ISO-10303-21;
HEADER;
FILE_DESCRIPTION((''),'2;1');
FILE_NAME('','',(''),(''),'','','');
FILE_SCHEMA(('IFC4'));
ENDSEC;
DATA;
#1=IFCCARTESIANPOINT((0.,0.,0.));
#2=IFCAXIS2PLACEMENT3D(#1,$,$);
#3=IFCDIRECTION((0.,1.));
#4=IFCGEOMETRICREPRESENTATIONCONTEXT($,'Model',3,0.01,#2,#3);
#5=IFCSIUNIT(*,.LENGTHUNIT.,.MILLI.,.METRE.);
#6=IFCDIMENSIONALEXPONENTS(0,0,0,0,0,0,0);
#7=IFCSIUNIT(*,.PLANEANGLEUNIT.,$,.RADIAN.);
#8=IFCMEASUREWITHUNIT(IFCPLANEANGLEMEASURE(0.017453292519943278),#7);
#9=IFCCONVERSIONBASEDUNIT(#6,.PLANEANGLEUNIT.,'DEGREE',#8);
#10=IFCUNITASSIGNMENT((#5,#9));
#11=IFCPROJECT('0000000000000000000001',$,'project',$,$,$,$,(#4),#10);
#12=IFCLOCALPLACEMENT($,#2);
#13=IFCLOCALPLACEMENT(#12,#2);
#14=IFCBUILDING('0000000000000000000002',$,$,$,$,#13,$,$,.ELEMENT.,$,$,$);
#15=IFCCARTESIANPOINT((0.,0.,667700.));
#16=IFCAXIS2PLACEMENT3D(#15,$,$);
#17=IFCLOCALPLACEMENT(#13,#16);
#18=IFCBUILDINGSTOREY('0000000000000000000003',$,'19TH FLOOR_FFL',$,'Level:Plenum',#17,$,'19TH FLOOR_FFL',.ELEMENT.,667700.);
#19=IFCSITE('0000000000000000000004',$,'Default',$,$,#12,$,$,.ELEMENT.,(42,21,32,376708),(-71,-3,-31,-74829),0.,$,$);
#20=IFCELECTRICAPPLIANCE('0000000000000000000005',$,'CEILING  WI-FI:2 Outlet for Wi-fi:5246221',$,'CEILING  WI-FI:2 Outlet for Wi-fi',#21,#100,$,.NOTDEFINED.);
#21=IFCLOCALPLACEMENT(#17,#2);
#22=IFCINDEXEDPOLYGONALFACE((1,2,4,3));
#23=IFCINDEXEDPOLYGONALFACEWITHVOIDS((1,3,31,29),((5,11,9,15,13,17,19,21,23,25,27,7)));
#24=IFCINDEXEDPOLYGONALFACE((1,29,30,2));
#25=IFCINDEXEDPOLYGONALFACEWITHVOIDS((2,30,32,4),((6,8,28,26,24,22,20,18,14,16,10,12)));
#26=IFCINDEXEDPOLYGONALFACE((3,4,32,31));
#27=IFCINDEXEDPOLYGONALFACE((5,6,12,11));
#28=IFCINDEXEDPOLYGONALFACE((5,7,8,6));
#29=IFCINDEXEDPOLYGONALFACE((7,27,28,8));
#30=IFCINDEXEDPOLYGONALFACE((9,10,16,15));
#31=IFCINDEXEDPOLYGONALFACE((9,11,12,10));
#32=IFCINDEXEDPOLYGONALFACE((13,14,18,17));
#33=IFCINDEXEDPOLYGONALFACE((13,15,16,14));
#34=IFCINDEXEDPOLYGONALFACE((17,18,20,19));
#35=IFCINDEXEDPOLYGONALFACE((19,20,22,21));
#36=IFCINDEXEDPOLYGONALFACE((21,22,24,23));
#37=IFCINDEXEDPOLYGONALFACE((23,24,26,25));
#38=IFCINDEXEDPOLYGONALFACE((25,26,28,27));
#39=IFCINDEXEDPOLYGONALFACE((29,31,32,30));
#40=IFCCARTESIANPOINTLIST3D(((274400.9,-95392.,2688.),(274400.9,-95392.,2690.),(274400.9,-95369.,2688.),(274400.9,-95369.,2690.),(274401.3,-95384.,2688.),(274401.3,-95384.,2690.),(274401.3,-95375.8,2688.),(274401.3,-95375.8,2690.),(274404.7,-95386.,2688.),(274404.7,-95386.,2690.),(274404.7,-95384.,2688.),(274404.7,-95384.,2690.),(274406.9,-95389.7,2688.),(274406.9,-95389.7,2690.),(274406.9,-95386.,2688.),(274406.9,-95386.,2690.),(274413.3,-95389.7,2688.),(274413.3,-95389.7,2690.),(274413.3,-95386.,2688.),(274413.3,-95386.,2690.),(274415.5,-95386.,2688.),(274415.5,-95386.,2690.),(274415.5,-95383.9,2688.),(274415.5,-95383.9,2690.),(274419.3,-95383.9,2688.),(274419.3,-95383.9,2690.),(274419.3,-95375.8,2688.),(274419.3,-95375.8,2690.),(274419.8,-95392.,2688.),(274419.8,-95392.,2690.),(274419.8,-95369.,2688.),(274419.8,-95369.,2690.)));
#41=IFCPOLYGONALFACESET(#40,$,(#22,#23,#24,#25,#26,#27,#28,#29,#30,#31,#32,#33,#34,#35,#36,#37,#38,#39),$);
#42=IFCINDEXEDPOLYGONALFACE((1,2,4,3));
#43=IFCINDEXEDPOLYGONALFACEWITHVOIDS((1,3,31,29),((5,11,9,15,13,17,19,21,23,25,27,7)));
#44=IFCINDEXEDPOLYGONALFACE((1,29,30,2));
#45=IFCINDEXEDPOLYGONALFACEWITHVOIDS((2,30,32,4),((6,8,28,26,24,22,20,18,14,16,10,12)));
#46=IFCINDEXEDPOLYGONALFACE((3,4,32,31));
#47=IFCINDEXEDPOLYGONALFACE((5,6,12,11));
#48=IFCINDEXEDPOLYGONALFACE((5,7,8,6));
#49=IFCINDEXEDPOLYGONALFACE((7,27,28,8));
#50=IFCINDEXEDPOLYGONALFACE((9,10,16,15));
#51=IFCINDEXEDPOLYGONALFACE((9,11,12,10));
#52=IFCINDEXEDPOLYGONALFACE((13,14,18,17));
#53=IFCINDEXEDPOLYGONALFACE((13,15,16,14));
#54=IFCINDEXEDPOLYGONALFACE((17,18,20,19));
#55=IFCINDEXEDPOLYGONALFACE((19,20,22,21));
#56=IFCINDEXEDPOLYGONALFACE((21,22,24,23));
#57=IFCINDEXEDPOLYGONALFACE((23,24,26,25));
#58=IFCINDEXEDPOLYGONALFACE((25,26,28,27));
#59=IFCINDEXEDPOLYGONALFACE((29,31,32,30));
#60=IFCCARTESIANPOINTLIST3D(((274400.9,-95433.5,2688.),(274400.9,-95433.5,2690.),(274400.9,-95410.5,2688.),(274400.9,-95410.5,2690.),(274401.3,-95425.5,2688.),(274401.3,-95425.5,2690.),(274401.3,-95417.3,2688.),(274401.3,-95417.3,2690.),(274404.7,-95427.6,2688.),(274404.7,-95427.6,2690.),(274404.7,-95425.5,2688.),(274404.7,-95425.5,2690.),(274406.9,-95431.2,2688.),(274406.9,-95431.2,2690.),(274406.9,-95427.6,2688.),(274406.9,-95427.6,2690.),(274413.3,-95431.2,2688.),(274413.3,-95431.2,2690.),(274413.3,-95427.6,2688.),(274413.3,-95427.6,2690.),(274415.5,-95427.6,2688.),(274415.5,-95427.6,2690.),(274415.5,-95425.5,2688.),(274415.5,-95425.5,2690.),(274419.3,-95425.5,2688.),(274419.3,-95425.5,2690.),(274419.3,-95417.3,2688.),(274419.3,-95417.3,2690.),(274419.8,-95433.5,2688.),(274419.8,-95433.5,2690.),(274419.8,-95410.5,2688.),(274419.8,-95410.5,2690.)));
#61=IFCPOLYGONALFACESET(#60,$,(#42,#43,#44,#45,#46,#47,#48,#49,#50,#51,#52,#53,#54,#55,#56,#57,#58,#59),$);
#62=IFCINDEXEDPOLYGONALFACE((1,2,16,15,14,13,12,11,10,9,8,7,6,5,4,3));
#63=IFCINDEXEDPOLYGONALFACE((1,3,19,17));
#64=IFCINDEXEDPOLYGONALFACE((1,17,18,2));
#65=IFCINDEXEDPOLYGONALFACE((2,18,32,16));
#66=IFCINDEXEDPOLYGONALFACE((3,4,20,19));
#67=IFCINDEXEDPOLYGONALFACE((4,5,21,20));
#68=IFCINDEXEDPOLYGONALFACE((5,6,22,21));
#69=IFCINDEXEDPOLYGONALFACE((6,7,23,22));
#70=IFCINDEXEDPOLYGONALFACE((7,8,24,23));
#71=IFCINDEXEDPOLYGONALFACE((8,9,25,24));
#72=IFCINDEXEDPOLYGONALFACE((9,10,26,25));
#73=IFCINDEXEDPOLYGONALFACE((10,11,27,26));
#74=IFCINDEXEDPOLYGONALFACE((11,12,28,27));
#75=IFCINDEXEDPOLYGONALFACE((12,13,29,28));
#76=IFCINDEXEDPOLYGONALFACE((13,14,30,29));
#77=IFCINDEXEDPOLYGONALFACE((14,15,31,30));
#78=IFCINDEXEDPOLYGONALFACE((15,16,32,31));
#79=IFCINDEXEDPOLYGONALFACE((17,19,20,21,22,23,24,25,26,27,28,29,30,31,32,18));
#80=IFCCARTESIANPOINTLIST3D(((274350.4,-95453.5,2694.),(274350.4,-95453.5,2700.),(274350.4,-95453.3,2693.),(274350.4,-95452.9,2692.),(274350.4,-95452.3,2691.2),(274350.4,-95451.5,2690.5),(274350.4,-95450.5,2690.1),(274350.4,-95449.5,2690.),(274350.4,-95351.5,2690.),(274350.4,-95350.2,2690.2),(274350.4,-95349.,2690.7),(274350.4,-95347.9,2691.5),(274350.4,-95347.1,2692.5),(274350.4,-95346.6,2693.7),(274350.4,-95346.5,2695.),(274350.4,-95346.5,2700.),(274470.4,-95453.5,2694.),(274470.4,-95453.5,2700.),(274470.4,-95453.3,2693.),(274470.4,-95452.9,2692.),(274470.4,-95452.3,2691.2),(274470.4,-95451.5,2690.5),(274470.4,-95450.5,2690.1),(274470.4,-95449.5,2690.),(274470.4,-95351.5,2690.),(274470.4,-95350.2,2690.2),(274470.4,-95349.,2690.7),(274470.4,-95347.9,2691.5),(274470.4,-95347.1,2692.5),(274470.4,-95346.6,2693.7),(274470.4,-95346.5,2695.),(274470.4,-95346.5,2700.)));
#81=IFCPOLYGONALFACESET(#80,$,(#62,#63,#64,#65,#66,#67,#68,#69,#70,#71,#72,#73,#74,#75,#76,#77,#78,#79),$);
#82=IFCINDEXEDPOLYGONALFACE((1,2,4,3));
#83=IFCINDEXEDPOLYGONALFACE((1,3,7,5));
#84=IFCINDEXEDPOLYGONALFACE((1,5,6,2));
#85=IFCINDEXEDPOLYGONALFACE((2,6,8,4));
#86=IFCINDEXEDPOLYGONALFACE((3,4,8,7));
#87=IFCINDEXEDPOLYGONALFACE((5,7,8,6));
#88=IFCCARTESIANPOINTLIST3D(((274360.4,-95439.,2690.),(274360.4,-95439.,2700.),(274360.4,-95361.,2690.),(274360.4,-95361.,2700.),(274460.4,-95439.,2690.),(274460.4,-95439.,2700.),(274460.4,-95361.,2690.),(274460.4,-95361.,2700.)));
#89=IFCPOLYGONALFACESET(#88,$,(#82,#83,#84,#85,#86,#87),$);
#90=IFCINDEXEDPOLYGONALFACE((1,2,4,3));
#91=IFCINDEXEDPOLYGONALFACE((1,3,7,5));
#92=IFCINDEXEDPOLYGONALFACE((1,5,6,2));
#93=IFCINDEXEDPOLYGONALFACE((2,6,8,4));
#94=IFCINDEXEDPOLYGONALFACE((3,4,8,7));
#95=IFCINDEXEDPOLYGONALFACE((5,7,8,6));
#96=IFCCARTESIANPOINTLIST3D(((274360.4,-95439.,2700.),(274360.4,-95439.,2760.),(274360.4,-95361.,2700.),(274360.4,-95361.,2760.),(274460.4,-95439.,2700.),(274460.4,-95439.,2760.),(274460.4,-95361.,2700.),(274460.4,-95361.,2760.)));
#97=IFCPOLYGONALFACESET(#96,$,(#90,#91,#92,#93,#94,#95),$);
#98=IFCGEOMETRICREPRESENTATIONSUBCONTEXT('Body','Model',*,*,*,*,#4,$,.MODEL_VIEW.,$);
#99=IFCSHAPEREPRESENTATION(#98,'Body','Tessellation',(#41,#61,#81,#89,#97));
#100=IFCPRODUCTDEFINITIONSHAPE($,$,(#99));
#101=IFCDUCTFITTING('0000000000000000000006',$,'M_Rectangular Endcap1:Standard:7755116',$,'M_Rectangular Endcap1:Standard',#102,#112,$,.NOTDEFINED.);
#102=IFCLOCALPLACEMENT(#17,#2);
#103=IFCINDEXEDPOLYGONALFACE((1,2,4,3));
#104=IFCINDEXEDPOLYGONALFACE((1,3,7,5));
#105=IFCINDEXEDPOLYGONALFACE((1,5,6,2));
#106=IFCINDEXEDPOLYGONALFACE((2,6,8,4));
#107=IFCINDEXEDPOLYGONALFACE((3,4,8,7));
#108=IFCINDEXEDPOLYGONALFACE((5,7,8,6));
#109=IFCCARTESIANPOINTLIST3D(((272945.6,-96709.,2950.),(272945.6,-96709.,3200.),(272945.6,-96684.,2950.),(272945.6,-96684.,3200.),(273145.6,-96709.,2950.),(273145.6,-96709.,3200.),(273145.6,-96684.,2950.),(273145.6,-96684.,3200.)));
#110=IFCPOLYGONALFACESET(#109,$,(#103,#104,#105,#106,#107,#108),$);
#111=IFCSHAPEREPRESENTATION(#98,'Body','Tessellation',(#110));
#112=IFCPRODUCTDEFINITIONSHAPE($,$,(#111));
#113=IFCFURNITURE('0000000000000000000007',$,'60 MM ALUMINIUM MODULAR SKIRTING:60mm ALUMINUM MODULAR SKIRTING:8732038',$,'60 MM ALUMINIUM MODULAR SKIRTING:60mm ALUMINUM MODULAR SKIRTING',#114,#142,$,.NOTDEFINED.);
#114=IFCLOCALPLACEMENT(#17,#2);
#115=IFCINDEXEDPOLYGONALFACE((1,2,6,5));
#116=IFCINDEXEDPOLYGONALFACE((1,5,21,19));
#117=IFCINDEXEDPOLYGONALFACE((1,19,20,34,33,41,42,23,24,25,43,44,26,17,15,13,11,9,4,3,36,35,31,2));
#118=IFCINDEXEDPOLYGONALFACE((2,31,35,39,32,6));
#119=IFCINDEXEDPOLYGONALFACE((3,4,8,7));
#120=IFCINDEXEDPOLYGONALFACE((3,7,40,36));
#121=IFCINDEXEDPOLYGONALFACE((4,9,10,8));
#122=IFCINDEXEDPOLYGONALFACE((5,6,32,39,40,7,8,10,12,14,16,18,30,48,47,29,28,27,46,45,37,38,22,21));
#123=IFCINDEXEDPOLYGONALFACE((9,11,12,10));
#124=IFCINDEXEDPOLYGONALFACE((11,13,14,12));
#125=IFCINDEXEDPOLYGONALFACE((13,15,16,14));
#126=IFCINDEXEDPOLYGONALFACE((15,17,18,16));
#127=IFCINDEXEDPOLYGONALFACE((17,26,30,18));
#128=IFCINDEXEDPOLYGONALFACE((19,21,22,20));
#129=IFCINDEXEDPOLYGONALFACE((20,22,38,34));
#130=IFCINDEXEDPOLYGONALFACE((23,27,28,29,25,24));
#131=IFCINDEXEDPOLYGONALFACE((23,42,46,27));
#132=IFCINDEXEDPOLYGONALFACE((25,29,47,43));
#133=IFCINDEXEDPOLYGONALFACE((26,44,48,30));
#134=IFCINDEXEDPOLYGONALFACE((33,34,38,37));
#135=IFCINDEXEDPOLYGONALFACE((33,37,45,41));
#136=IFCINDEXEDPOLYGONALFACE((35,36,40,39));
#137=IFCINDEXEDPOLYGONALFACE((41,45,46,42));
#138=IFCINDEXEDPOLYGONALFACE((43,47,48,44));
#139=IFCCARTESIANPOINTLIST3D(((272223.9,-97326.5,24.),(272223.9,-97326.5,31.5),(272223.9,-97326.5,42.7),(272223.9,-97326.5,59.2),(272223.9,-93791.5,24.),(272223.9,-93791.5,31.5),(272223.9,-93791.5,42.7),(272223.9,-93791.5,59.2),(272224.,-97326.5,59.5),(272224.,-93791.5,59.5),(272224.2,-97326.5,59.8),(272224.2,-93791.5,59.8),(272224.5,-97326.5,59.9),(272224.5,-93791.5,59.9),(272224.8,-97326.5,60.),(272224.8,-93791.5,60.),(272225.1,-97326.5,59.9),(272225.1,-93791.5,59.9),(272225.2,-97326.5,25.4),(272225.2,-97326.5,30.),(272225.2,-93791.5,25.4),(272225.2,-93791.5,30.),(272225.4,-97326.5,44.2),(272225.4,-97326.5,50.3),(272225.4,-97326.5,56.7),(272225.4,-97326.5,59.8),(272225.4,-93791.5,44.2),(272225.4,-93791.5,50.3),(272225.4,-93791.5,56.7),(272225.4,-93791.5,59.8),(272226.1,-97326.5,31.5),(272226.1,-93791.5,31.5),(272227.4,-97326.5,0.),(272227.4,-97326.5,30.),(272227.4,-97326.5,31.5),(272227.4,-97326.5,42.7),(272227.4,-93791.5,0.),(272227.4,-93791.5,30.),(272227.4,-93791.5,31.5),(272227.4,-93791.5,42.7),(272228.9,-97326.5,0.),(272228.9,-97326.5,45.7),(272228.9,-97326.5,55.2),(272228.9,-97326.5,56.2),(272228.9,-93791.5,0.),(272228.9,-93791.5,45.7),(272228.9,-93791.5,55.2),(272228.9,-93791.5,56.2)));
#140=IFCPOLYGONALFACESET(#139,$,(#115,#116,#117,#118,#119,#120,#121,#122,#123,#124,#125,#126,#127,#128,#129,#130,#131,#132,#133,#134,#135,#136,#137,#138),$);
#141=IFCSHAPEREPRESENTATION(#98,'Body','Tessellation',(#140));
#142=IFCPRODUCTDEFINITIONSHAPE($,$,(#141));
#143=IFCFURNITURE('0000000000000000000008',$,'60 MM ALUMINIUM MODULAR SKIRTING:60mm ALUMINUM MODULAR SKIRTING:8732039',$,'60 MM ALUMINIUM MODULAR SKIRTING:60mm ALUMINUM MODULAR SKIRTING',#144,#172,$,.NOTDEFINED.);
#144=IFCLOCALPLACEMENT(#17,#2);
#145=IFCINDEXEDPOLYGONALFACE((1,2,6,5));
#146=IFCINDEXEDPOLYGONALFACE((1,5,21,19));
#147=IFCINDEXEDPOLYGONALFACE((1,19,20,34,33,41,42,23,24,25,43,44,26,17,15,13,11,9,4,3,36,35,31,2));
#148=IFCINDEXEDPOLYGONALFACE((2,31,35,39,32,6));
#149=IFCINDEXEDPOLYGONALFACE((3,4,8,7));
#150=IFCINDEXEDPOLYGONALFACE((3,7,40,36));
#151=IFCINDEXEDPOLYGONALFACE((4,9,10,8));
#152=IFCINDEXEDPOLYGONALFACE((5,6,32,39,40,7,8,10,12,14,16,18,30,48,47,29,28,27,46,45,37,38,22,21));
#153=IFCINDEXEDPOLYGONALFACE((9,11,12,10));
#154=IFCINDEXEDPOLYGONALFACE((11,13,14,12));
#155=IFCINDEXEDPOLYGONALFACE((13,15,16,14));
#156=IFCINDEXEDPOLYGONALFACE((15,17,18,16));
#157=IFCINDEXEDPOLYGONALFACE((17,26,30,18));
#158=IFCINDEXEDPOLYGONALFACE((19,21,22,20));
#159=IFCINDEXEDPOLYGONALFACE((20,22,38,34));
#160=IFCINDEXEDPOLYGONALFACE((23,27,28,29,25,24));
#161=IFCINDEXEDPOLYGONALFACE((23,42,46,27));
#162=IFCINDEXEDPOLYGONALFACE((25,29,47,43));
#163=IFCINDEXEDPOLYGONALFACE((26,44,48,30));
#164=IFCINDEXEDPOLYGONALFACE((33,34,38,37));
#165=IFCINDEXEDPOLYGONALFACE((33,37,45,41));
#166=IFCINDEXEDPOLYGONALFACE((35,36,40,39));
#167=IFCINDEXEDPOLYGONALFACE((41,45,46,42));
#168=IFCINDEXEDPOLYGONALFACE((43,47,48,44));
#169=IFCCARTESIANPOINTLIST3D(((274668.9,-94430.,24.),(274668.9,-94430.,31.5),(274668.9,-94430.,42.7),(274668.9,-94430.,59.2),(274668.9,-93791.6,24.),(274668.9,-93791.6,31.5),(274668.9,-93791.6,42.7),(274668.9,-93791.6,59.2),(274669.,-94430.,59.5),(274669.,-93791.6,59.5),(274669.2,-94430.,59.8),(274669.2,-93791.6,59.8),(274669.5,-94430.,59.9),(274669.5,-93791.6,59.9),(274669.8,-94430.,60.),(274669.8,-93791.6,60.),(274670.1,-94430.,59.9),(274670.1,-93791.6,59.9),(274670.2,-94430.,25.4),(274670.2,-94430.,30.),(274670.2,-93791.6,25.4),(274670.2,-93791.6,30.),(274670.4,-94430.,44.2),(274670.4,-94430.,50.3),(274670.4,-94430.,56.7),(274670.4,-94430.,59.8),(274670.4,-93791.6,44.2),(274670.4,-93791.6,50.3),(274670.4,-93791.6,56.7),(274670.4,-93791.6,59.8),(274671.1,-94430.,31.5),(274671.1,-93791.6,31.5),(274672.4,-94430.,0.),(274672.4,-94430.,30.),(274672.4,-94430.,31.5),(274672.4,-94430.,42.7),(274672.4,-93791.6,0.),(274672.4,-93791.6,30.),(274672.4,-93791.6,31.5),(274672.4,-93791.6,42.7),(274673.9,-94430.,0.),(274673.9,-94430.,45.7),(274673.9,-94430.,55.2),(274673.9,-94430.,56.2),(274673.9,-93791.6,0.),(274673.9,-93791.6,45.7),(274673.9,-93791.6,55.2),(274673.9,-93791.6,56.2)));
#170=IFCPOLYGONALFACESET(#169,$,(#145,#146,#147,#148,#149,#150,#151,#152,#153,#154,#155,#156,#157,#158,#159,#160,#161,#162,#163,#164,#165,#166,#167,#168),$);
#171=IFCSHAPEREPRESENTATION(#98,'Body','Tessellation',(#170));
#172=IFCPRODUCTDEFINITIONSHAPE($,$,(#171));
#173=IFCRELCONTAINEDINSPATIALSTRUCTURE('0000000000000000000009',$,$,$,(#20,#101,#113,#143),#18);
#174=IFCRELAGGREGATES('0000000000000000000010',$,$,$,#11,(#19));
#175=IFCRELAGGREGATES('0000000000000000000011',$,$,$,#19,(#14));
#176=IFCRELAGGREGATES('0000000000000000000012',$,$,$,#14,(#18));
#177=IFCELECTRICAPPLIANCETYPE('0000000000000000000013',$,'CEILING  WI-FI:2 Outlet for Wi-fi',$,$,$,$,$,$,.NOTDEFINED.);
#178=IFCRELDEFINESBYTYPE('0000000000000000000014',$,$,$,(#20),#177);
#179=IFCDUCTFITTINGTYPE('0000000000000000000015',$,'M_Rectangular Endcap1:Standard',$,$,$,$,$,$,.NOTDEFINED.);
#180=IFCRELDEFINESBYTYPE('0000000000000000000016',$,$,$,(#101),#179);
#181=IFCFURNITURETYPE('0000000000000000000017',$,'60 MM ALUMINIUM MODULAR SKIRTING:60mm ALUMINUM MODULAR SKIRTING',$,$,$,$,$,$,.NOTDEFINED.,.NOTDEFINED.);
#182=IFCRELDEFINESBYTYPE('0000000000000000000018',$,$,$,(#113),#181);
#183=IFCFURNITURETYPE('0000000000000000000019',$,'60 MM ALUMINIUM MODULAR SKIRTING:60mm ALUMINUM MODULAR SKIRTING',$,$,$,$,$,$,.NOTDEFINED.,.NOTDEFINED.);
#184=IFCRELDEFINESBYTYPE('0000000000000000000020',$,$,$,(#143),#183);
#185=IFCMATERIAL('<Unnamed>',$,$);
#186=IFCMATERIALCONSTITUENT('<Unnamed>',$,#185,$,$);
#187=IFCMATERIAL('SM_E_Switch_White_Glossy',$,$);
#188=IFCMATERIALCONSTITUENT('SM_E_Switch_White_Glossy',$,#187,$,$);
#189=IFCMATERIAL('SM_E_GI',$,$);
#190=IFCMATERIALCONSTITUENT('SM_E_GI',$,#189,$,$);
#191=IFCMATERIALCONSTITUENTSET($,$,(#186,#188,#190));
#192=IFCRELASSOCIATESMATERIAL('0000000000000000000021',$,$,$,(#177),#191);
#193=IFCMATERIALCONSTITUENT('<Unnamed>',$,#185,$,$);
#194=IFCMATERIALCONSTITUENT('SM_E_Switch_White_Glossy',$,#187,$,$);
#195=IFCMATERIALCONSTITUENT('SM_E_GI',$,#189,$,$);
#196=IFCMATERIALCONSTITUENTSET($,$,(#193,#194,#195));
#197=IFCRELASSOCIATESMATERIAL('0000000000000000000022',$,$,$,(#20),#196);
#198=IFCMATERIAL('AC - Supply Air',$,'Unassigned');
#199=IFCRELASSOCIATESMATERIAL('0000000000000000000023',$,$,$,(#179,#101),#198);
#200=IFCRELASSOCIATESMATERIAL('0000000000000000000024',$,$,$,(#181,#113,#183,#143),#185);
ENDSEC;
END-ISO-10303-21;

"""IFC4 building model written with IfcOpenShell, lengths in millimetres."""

from ifc_helpers import new_model, entity, si_unit, converted_unit, direction, frame, origin, place, context, subcontext, project, spatial, line, arc, indexed_curve, outline, extrude, source, transform, mapped, material, constituent, constituent_set, type_object, type_shapes, element, save


model = new_model("IFC4")

# Units and contexts
model_context = context("Model", 3, precision=0.01, world=origin(), true_north=direction((0.0, 1.0)))
body_context = subcontext(model_context, "Body", "Model", "MODEL_VIEW")
ifc_project = project(units=[si_unit("LENGTHUNIT", "METRE", prefix="MILLI"), converted_unit("PLANEANGLEUNIT", "DEGREE", entity("IfcPlaneAngleMeasure", 0.017453292519943278), si_unit("PLANEANGLEUNIT", "RADIAN"), dimensions=[0, 0, 0, 0, 0, 0, 0])], contexts=[model_context])

# Site, building, storey
site_placement = place(None, origin())
site = spatial("IfcSite", under=ifc_project, at=site_placement, Name="Default", CompositionType="ELEMENT", RefLatitude=(42, 21, 32, 376708), RefLongitude=(-71, -3, -31, -74829), RefElevation=0.0)
building_placement = place(site_placement, origin())
building = spatial("IfcBuilding", under=site, at=building_placement, CompositionType="ELEMENT")
storey_placement = place(building_placement, frame((0.0, 0.0, 667700.0)))
storey = spatial("IfcBuildingStorey", under=building, at=storey_placement, Name="19TH FLOOR_FFL", ObjectType="Level:Plenum", LongName="19TH FLOOR_FFL", CompositionType="ELEMENT", Elevation=667700.0)

# Shared definitions
ifc_material_1 = material(Name="<Unnamed>")

# Electric appliance
ifc_constituent_1 = constituent(ifc_material_1, Name="<Unnamed>")
ifc_material_2 = material(Name="SM_E_Switch_White_Glossy")
ifc_constituent_2 = constituent(ifc_material_2, Name="SM_E_Switch_White_Glossy")
ifc_material_3 = material(Name="SM_E_GI")
ifc_constituent_3 = constituent(ifc_material_3, Name="SM_E_GI")
ifc_constituent_set_1 = constituent_set(constituents=[ifc_constituent_1, ifc_constituent_2, ifc_constituent_3])
ifc_constituent_4 = constituent(ifc_material_1, Name="<Unnamed>")
ifc_constituent_5 = constituent(ifc_material_2, Name="SM_E_Switch_White_Glossy")
ifc_constituent_6 = constituent(ifc_material_3, Name="SM_E_GI")
ifc_constituent_set_2 = constituent_set(constituents=[ifc_constituent_4, ifc_constituent_5, ifc_constituent_6])
electric_appliance_type = type_object("IfcElectricApplianceType", Name="CEILING  WI-FI:2 Outlet for Wi-fi", PredefinedType="NOTDEFINED", material=ifc_constituent_set_2)
shared_shape_1 = source(origin(), body_context, "Body", "SweptSolid", [
    extrude(outline(indexed_curve([(-11.5, -9.5), (11.5, -9.5), (11.5, 9.5), (-11.5, 9.5), (-11.5, -9.5)], self_intersect=False), holes=[indexed_curve([(3.5, 9.1), (3.5, 5.6), (5.5, 5.6), (5.5, 3.4), (9.2, 3.4), (9.2, -3.0), (5.5, -3.0), (5.5, -5.2), (3.4, -5.2), (3.4, -8.9), (-4.7, -8.9), (-4.7, 9.1), (3.5, 9.1)], self_intersect=False)]), frame((0.0, -73.0, 10.0), z_axis=(0.0, 0.0, 1.0), x_axis=(0.0, 1.0, 0.0)), (0.0, 0.0, 1.0), 2.0),
    extrude(outline(indexed_curve([(-11.5, -9.5), (11.5, -9.5), (11.5, 9.5), (-11.5, 9.5), (-11.5, -9.5)], self_intersect=False), holes=[indexed_curve([(3.5, 9.1), (3.5, 5.6), (5.5, 5.6), (5.5, 3.4), (9.2, 3.4), (9.2, -3.0), (5.5, -3.0), (5.5, -5.2), (3.4, -5.2), (3.4, -8.9), (-4.7, -8.9), (-4.7, 9.1), (3.5, 9.1)], self_intersect=False)]), frame((0.0, -31.4, 10.0), z_axis=(0.0, 0.0, 1.0), x_axis=(0.0, 1.0, 0.0)), (0.0, 0.0, 1.0), 2.0),
    extrude(outline(indexed_curve([(-53.7, -5.2), (53.3, -5.2), (53.3, 0.8), (52.2, 3.7), (49.3, 4.8), (-48.7, 4.8), (-52.2, 3.4), (-53.7, -0.2)], segments=[line(1, 2, 3), arc(3, 4, 5), line(5, 6), arc(6, 7, 8), line(8, 1)], self_intersect=False)), frame((-60.0, -53.3, 5.2), z_axis=(1.0, 0.0, 0.0), x_axis=(0.0, 1.0, 0.0)), (0.0, 0.0, 1.0), 120.0),
    extrude(outline(indexed_curve([(-50.0, -39.0), (50.0, -39.0), (50.0, 39.0), (-50.0, 39.0), (-50.0, -39.0)], self_intersect=False)), frame((0.0, -53.5, 0.0), z_axis=(0.0, 0.0, 1.0), x_axis=(-1.0, 0.0, 0.0)), (0.0, 0.0, 1.0), 10.0),
    extrude(outline(indexed_curve([(-50.0, -39.0), (50.0, -39.0), (50.0, 39.0), (-50.0, 39.0), (-50.0, -39.0)], self_intersect=False)), frame((0.0, -53.5, -60.0), z_axis=(0.0, 0.0, 1.0), x_axis=(-1.0, 0.0, 0.0)), (0.0, 0.0, 1.0), 60.0),
])
type_shapes(electric_appliance_type, [shared_shape_1])
electric_appliance_placement = place(storey_placement, frame((274410.4, -95453.5, 2700.0), z_axis=(0.0, 0.0, -1.0), x_axis=(1.0, 0.0, 0.0)))
element("IfcElectricAppliance", 1, at=electric_appliance_placement, inside=storey, type_object=electric_appliance_type, material=ifc_constituent_set_1, Name="CEILING  WI-FI:2 Outlet for Wi-fi:5246221", ObjectType="CEILING  WI-FI:2 Outlet for Wi-fi", PredefinedType="NOTDEFINED", context=body_context, shape_type="MappedRepresentation", body=[
    mapped(shared_shape_1, transform((0.0, 0.0, 0.0), scale=1.0)),
])

# Duct fitting
ifc_material_4 = material(Name="AC - Supply Air", Category="Unassigned")
duct_fitting_type_1 = type_object("IfcDuctFittingType", Name="M_Rectangular Endcap1:Standard", PredefinedType="NOTDEFINED", material=ifc_material_4)
shared_shape_2 = source(origin(), body_context, "Body", "SweptSolid", [
    extrude(outline(indexed_curve([(-12.5, -100.0), (12.5, -100.0), (12.5, 100.0), (-12.5, 100.0), (-12.5, -100.0)], self_intersect=False)), frame((12.5, 0.0, -125.0)), (0.0, 0.0, 1.0), 250.0),
])
type_shapes(duct_fitting_type_1, [shared_shape_2])
duct_fitting_1_placement = place(storey_placement, frame((273045.6, -96684.0, 3075.0), z_axis=(0.0, 0.0, 1.0), x_axis=(0.0, -1.0, 0.0)))
element("IfcDuctFitting", 2, at=duct_fitting_1_placement, inside=storey, type_object=duct_fitting_type_1, material=ifc_material_4, Name="M_Rectangular Endcap1:Standard:7755116", ObjectType="M_Rectangular Endcap1:Standard", PredefinedType="NOTDEFINED", context=body_context, shape_type="MappedRepresentation", body=[
    mapped(shared_shape_2, transform((0.0, 0.0, 0.0), scale=1.0)),
])

# Furniture
furniture_type_1 = type_object("IfcFurnitureType", Name="60 MM ALUMINIUM MODULAR SKIRTING:60mm ALUMINUM MODULAR SKIRTING", AssemblyPlace="NOTDEFINED", PredefinedType="NOTDEFINED", material=ifc_material_1)
shared_shape_3 = source(origin(), body_context, "Body", "SweptSolid", [
    extrude(outline(indexed_curve([(-18.5, -2.7), (-17.5, -2.7), (-19.0, 0.8), (-12.6, 0.8), (-6.5, 0.8), (-8.0, -2.7), (37.7, -2.7), (37.7, -1.2), (7.7, -1.2), (7.7, 1.0), (12.3, 1.0), (13.7, 2.4), (6.2, 2.4), (6.2, 0.2), (6.2, -1.2), (-5.0, -1.2), (-5.0, 2.4), (-21.4, 2.3), (-22.2, 1.8), (-22.0, 0.9)], segments=[line(1, 2, 3, 4, 5, 6, 7, 8, 9, 10, 11, 12, 13, 14, 15, 16, 17, 18), arc(18, 19, 20), line(20, 1)], self_intersect=False)), frame((0.0, -2.4, 37.7), z_axis=(1.0, 0.0, 0.0), x_axis=(0.0, 0.0, -1.0)), (0.0, 0.0, 1.0), 3535.0),
])
type_shapes(furniture_type_1, [shared_shape_3])
furniture_1_placement = place(storey_placement, frame((272223.9, -97326.5, 0.0), z_axis=(0.0, 0.0, 1.0), x_axis=(0.0, 1.0, 0.0)))
element("IfcFurniture", 3, at=furniture_1_placement, inside=storey, type_object=furniture_type_1, material=ifc_material_1, Name="60 MM ALUMINIUM MODULAR SKIRTING:60mm ALUMINUM MODULAR SKIRTING:8732038", ObjectType="60 MM ALUMINIUM MODULAR SKIRTING:60mm ALUMINUM MODULAR SKIRTING", PredefinedType="NOTDEFINED", context=body_context, shape_type="MappedRepresentation", body=[
    mapped(shared_shape_3, transform((0.0, 0.0, 0.0), scale=1.0)),
])
furniture_type_2 = type_object("IfcFurnitureType", Name="60 MM ALUMINIUM MODULAR SKIRTING:60mm ALUMINUM MODULAR SKIRTING", AssemblyPlace="NOTDEFINED", PredefinedType="NOTDEFINED", material=ifc_material_1)
shared_shape_4 = source(origin(), body_context, "Body", "SweptSolid", [
    extrude(outline(indexed_curve([(-18.5, -2.7), (-17.5, -2.7), (-19.0, 0.8), (-12.6, 0.8), (-6.5, 0.8), (-8.0, -2.7), (37.7, -2.7), (37.7, -1.2), (7.7, -1.2), (7.7, 1.0), (12.3, 1.0), (13.7, 2.4), (6.2, 2.4), (6.2, 0.2), (6.2, -1.2), (-5.0, -1.2), (-5.0, 2.4), (-21.4, 2.3), (-22.2, 1.8), (-22.0, 0.9)], segments=[line(1, 2, 3, 4, 5, 6, 7, 8, 9, 10, 11, 12, 13, 14, 15, 16, 17, 18), arc(18, 19, 20), line(20, 1)], self_intersect=False)), frame((0.0, -2.4, 37.7), z_axis=(1.0, 0.0, 0.0), x_axis=(0.0, 0.0, -1.0)), (0.0, 0.0, 1.0), 638.3),
])
type_shapes(furniture_type_2, [shared_shape_4])
furniture_2_placement = place(storey_placement, frame((274668.9, -94430.0, 0.0), z_axis=(0.0, 0.0, 1.0), x_axis=(0.0, 1.0, 0.0)))
element("IfcFurniture", 4, at=furniture_2_placement, inside=storey, type_object=furniture_type_2, material=ifc_material_1, Name="60 MM ALUMINIUM MODULAR SKIRTING:60mm ALUMINUM MODULAR SKIRTING:8732039", ObjectType="60 MM ALUMINIUM MODULAR SKIRTING:60mm ALUMINUM MODULAR SKIRTING", PredefinedType="NOTDEFINED", context=body_context, shape_type="MappedRepresentation", body=[
    mapped(shared_shape_4, transform((0.0, 0.0, 0.0), scale=1.0)),
])

save(model, "model.ifc")
